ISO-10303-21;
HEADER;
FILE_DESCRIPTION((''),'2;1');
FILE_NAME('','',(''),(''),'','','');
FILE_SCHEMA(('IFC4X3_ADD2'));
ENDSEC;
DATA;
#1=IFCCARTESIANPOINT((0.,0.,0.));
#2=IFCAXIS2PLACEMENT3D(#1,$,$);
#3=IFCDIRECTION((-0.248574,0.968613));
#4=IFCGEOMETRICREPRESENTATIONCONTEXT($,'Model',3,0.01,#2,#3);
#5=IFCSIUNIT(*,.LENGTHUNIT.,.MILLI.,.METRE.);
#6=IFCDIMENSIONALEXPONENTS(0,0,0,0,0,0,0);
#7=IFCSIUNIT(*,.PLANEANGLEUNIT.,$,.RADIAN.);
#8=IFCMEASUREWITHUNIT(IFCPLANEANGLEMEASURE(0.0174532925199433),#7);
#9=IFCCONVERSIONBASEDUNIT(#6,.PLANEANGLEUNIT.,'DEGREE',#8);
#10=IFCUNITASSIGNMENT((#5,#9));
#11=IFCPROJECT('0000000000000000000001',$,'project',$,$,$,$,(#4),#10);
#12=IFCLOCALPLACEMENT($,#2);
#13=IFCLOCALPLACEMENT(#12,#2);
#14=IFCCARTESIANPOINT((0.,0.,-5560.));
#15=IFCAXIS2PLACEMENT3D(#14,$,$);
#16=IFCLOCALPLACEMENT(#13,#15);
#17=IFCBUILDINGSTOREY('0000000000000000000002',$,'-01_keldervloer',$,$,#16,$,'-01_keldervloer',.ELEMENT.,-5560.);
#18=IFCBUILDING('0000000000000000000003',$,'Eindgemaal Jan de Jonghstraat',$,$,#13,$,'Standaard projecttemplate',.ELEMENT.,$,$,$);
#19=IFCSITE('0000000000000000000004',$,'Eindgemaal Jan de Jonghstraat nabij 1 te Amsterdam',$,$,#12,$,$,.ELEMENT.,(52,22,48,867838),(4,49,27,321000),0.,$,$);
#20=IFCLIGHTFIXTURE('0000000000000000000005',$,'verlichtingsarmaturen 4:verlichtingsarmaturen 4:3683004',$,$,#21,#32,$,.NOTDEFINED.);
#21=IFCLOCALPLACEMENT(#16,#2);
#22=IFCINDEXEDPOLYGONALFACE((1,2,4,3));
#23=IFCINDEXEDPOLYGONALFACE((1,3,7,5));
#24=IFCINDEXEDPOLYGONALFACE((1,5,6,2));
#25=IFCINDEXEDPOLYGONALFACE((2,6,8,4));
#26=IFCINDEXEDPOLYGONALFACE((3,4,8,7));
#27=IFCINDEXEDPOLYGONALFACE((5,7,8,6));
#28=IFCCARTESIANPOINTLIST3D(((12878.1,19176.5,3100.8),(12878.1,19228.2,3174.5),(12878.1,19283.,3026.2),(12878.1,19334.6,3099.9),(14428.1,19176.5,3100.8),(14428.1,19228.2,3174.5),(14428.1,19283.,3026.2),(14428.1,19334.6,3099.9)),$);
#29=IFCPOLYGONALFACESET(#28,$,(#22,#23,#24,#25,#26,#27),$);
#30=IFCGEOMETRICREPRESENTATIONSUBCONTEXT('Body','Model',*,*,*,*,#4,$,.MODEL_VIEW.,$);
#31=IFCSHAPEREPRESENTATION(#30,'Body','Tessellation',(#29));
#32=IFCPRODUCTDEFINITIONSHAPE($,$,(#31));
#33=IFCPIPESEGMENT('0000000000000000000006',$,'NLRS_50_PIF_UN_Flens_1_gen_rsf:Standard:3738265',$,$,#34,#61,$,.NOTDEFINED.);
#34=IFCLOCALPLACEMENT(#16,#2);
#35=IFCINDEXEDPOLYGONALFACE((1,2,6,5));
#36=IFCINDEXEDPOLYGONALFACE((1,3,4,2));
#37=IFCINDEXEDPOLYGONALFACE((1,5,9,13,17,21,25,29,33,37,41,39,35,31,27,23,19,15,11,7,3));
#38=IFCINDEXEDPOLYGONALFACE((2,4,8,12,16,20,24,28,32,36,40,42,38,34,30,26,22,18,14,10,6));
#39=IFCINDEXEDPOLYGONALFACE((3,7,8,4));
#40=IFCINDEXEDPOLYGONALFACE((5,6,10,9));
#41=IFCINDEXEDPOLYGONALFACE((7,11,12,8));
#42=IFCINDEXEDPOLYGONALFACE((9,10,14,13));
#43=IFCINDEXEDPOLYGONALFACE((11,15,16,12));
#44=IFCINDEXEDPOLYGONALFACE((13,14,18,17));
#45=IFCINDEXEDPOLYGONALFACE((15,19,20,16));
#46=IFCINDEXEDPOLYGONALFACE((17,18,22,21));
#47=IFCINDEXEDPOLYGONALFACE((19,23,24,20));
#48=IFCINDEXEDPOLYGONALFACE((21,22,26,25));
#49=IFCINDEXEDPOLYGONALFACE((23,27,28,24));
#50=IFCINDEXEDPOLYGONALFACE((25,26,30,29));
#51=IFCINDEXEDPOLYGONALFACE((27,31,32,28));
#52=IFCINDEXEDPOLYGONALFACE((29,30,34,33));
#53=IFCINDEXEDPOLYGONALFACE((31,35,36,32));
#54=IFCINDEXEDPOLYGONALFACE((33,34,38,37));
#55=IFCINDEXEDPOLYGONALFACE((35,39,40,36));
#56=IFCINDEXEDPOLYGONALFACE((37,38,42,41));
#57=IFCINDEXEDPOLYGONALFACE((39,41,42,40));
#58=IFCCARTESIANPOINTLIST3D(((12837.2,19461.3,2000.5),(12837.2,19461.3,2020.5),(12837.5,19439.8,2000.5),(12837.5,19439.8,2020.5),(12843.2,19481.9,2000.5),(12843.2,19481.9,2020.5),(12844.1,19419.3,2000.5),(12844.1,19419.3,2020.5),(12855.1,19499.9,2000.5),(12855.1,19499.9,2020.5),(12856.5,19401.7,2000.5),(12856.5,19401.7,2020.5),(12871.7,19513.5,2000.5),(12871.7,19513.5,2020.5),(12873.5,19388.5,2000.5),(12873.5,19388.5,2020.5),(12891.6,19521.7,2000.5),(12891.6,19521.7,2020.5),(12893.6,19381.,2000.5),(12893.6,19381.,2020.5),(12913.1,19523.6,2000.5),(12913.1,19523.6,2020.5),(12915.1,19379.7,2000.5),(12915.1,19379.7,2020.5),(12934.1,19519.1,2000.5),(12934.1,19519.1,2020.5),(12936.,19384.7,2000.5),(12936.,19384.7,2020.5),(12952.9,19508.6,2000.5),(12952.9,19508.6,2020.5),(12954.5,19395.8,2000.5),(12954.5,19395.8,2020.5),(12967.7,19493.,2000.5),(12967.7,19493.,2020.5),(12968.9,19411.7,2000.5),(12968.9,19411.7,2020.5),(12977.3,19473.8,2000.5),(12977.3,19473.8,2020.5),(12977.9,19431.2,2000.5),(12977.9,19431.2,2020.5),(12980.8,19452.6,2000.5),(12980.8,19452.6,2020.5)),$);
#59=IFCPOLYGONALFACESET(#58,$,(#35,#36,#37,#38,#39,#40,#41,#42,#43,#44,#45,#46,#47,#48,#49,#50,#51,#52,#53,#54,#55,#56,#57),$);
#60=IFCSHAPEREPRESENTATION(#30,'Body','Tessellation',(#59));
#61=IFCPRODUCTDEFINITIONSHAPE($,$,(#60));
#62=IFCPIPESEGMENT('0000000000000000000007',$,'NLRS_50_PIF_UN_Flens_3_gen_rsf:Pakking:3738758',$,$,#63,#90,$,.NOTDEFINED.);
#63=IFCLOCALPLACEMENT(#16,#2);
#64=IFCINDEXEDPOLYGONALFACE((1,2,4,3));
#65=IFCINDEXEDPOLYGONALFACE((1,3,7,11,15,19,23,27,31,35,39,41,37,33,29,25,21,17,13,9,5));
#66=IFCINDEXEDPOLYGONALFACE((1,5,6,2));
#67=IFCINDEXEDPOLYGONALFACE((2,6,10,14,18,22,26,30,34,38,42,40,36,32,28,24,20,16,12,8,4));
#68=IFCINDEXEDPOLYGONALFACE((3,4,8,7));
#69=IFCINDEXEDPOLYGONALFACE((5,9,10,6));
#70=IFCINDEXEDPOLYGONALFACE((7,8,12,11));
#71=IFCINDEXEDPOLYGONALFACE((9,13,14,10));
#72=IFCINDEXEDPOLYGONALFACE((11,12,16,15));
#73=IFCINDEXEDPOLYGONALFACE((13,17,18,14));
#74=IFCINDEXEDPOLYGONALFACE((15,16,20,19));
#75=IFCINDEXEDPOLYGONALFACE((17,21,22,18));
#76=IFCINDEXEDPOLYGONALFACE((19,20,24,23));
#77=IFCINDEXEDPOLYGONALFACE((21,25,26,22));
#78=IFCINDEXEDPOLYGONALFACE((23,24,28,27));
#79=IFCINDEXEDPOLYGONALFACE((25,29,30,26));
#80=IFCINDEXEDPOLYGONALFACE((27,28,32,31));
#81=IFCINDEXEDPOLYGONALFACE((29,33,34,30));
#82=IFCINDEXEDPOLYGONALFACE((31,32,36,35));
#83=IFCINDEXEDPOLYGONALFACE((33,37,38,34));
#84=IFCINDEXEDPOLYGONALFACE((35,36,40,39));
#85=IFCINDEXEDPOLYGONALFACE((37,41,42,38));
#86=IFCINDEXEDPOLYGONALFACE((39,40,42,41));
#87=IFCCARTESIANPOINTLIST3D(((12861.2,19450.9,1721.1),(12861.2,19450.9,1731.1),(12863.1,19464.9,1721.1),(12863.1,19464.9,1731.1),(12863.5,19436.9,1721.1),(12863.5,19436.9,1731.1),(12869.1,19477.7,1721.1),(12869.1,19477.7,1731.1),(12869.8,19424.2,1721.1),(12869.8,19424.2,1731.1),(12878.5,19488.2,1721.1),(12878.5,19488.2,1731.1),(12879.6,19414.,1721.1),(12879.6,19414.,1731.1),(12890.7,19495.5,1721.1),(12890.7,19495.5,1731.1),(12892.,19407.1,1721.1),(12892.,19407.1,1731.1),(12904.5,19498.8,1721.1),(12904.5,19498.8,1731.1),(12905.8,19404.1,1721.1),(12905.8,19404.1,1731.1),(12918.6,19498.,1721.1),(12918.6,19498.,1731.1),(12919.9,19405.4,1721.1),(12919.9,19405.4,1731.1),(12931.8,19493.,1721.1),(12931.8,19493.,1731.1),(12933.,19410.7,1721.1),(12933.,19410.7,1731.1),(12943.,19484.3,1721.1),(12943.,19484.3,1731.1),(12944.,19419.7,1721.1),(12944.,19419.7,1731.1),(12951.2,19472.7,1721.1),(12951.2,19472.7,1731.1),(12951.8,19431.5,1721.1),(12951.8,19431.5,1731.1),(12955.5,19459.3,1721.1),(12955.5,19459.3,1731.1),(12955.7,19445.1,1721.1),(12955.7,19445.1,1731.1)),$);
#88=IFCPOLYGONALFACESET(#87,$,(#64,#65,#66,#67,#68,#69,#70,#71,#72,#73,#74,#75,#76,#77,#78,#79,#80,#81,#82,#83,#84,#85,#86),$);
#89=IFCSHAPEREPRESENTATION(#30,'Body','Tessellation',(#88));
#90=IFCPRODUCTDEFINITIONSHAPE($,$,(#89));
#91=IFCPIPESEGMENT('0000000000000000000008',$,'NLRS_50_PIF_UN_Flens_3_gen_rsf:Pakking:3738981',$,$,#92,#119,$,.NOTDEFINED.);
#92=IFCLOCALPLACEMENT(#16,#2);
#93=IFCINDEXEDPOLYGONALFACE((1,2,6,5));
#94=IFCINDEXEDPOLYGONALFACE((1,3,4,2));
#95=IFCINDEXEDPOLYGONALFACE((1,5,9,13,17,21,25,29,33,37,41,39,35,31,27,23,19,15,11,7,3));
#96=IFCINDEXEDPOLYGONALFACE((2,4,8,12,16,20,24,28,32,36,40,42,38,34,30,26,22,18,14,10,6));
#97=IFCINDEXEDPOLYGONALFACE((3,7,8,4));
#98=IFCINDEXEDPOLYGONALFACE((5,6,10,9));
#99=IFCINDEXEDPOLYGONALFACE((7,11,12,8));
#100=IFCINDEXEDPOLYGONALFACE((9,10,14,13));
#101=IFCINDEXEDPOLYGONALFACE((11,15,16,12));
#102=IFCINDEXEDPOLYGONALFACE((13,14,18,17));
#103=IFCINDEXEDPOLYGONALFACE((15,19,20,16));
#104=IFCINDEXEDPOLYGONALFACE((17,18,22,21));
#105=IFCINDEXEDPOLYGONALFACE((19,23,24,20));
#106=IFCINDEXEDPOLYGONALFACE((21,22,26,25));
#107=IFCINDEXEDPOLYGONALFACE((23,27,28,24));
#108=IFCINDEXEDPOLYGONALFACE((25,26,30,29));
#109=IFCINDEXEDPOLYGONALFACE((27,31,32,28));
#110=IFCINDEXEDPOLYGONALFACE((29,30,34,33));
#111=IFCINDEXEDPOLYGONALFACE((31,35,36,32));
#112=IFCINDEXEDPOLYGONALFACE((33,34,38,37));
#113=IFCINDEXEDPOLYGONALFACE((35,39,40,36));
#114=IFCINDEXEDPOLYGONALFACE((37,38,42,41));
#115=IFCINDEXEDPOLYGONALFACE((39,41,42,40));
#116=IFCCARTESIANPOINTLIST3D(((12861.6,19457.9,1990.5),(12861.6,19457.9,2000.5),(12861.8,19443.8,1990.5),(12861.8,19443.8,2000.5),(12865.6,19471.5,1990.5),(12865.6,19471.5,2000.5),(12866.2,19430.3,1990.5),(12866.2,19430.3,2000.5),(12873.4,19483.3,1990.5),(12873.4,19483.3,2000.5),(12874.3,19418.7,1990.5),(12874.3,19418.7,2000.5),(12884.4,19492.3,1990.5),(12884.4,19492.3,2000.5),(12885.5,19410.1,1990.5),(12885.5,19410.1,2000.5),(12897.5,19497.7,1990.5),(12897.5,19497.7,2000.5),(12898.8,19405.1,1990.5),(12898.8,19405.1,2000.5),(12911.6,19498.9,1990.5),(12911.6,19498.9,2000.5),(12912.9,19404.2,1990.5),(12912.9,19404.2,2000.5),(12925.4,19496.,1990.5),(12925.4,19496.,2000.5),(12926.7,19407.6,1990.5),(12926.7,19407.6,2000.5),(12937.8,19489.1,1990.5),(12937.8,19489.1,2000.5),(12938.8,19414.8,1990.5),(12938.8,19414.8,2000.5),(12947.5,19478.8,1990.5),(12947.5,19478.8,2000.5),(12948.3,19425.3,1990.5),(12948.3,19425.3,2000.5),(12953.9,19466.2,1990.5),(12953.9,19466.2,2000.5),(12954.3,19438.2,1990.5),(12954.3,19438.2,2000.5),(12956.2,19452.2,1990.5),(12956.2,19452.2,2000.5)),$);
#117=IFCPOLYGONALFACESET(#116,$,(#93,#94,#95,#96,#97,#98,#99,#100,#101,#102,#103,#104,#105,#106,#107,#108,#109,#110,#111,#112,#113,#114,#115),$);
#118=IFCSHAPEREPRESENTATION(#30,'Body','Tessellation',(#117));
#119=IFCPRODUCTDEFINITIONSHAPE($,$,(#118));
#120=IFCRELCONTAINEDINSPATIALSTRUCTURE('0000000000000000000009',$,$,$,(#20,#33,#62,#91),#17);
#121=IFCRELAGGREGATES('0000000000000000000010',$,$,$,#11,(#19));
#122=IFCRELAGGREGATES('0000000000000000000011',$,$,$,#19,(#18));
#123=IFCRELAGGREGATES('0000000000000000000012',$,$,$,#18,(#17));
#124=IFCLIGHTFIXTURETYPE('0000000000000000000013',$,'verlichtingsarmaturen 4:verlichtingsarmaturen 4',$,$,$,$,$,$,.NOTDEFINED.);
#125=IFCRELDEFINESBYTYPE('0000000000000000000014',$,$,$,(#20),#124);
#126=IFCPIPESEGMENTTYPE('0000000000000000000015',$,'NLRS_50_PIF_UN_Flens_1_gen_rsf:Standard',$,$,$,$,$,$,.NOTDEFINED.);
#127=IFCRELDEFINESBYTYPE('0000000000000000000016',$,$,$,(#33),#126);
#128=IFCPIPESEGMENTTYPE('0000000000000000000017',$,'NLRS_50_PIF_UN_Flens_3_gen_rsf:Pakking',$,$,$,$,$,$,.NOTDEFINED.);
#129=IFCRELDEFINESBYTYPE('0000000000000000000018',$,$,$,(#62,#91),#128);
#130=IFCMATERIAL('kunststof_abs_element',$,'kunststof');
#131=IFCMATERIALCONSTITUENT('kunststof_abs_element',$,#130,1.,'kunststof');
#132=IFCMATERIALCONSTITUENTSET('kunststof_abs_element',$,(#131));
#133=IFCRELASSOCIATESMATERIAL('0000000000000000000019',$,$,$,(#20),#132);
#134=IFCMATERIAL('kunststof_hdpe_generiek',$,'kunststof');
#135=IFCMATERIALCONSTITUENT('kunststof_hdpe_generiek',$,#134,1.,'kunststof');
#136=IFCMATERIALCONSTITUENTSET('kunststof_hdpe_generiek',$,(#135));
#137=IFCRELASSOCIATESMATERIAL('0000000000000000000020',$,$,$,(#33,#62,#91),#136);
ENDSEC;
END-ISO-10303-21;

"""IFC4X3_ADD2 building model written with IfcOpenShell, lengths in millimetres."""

from ifc_helpers import new_model, entity, si_unit, converted_unit, direction, frame, frame_2d, origin, origin_2d_with_axis, place, context, subcontext, project, spatial, rectangle, circle, extrude, source, transform, mapped, material, constituent, constituent_set, type_object, type_shapes, element, save


model = new_model("IFC4X3_ADD2")

# Units and contexts
model_context = context("Model", 3, precision=0.01, world=origin(), true_north=direction((-0.248574, 0.968613)))
body_context = subcontext(model_context, "Body", "Model", "MODEL_VIEW")
ifc_project = project(units=[si_unit("LENGTHUNIT", "METRE", prefix="MILLI"), converted_unit("PLANEANGLEUNIT", "DEGREE", entity("IfcPlaneAngleMeasure", 0.0174532925199433), si_unit("PLANEANGLEUNIT", "RADIAN"), dimensions=[0, 0, 0, 0, 0, 0, 0])], contexts=[model_context])

# Site, building, storey
site_placement = place(None, origin())
site = spatial("IfcSite", under=ifc_project, at=site_placement, Name="Eindgemaal Jan de Jonghstraat nabij 1 te Amsterdam", CompositionType="ELEMENT", RefLatitude=(52, 22, 48, 867838), RefLongitude=(4, 49, 27, 321000), RefElevation=0.0)
building_placement = place(site_placement, origin())
building = spatial("IfcBuilding", under=site, at=building_placement, Name="Eindgemaal Jan de Jonghstraat", LongName="Standaard projecttemplate", CompositionType="ELEMENT")
storey_placement = place(building_placement, frame((0.0, 0.0, -5560.0)))
storey = spatial("IfcBuildingStorey", under=building, at=storey_placement, Name="-01_keldervloer", LongName="-01_keldervloer", CompositionType="ELEMENT", Elevation=-5560.0)

# Shared definitions
ifc_material_1 = material(Name="kunststof_hdpe_generiek", Category="kunststof")
ifc_constituent_1 = constituent(ifc_material_1, Name="kunststof_hdpe_generiek", Category="kunststof", fraction=1.0)
ifc_constituent_set_1 = constituent_set(constituents=[ifc_constituent_1], Name="kunststof_hdpe_generiek")

# Light fixture
ifc_material_2 = material(Name="kunststof_abs_element", Category="kunststof")
ifc_constituent_2 = constituent(ifc_material_2, Name="kunststof_abs_element", Category="kunststof", fraction=1.0)
ifc_constituent_set_2 = constituent_set(constituents=[ifc_constituent_2], Name="kunststof_abs_element")
light_fixture_type = type_object("IfcLightFixtureType", Name="verlichtingsarmaturen 4:verlichtingsarmaturen 4", PredefinedType="NOTDEFINED")
shared_shape_1 = source(origin(), body_context, "Body", "SweptSolid", [
    extrude(rectangle(XDim=90.0, YDim=130.0, at=origin_2d_with_axis()), frame((-775.0, 0.0, 0.0), z_axis=(1.0, 0.0, 0.0), x_axis=(0.0, 0.573576, 0.819152)), (0.0, 0.0, 1.0), 1550.0),
])
type_shapes(light_fixture_type, [shared_shape_1])
light_fixture_placement = place(storey_placement, frame((13653.1, 19255.6, 3100.3)))
element("IfcLightFixture", 1, at=light_fixture_placement, inside=storey, type_object=light_fixture_type, material=ifc_constituent_set_2, Name="verlichtingsarmaturen 4:verlichtingsarmaturen 4:3683004", PredefinedType="NOTDEFINED", context=body_context, shape_type="MappedRepresentation", body=[
    mapped(shared_shape_1, transform((0.0, 0.0, 0.0), scale=1.0)),
])

# Pipe segments
pipe_segment_type_1 = type_object("IfcPipeSegmentType", Name="NLRS_50_PIF_UN_Flens_1_gen_rsf:Standard", PredefinedType="NOTDEFINED")
shared_shape_2 = source(origin(), body_context, "Body", "SweptSolid", [
    extrude(circle(Radius=72.2, at=frame_2d((0.0, 0.0), x_axis=(1.0, 0.0))), frame((-10.0, 0.0, 0.0), z_axis=(1.0, 0.0, 0.0), x_axis=(0.0, 1.0, 0.0)), (0.0, 0.0, 1.0), 20.0),
])
type_shapes(pipe_segment_type_1, [shared_shape_2])
pipe_segment_1_placement = place(storey_placement, frame((12908.7, 19451.5, 2010.5), z_axis=(-0.014169, 0.9999, 0.0), x_axis=(0.0, 0.0, 1.0)))
element("IfcPipeSegment", 2, at=pipe_segment_1_placement, inside=storey, type_object=pipe_segment_type_1, material=ifc_constituent_set_1, Name="NLRS_50_PIF_UN_Flens_1_gen_rsf:Standard:3738265", PredefinedType="NOTDEFINED", context=body_context, shape_type="MappedRepresentation", body=[
    mapped(shared_shape_2, transform((0.0, 0.0, 0.0), scale=1.0)),
])
pipe_segment_type_2 = type_object("IfcPipeSegmentType", Name="NLRS_50_PIF_UN_Flens_3_gen_rsf:Pakking", PredefinedType="NOTDEFINED")
shared_shape_3 = source(origin(), body_context, "Body", "SweptSolid", [
    extrude(circle(Radius=47.5, at=frame_2d((0.0, 0.0), x_axis=(1.0, 0.0))), frame((0.0, 0.0, 0.0), z_axis=(0.0, 0.0, 1.0), x_axis=(0.0, -1.0, 0.0)), (0.0, 0.0, 1.0), 10.0),
])
type_shapes(pipe_segment_type_2, [shared_shape_3])
for number, where, z_axis, x_axis, name in (
    (3, (12908.7, 19451.5, 1731.1), (0.0, 0.0, -1.0), (-0.014169, 0.9999, 0.0), "NLRS_50_PIF_UN_Flens_3_gen_rsf:Pakking:3738758"),
    (4, (12908.7, 19451.5, 1990.5), (0.0, 0.0, 1.0), (-0.014169, 0.9999, 0.0), "NLRS_50_PIF_UN_Flens_3_gen_rsf:Pakking:3738981"),
):
    element("IfcPipeSegment", number, at=place(storey_placement, frame(where, z_axis=z_axis, x_axis=x_axis)), inside=storey, type_object=pipe_segment_type_2, material=ifc_constituent_set_1, Name=name, PredefinedType="NOTDEFINED", context=body_context, shape_type="MappedRepresentation", body=[
        mapped(shared_shape_3, transform((0.0, 0.0, 0.0), scale=1.0)),
    ])

save(model, "model.ifc")
